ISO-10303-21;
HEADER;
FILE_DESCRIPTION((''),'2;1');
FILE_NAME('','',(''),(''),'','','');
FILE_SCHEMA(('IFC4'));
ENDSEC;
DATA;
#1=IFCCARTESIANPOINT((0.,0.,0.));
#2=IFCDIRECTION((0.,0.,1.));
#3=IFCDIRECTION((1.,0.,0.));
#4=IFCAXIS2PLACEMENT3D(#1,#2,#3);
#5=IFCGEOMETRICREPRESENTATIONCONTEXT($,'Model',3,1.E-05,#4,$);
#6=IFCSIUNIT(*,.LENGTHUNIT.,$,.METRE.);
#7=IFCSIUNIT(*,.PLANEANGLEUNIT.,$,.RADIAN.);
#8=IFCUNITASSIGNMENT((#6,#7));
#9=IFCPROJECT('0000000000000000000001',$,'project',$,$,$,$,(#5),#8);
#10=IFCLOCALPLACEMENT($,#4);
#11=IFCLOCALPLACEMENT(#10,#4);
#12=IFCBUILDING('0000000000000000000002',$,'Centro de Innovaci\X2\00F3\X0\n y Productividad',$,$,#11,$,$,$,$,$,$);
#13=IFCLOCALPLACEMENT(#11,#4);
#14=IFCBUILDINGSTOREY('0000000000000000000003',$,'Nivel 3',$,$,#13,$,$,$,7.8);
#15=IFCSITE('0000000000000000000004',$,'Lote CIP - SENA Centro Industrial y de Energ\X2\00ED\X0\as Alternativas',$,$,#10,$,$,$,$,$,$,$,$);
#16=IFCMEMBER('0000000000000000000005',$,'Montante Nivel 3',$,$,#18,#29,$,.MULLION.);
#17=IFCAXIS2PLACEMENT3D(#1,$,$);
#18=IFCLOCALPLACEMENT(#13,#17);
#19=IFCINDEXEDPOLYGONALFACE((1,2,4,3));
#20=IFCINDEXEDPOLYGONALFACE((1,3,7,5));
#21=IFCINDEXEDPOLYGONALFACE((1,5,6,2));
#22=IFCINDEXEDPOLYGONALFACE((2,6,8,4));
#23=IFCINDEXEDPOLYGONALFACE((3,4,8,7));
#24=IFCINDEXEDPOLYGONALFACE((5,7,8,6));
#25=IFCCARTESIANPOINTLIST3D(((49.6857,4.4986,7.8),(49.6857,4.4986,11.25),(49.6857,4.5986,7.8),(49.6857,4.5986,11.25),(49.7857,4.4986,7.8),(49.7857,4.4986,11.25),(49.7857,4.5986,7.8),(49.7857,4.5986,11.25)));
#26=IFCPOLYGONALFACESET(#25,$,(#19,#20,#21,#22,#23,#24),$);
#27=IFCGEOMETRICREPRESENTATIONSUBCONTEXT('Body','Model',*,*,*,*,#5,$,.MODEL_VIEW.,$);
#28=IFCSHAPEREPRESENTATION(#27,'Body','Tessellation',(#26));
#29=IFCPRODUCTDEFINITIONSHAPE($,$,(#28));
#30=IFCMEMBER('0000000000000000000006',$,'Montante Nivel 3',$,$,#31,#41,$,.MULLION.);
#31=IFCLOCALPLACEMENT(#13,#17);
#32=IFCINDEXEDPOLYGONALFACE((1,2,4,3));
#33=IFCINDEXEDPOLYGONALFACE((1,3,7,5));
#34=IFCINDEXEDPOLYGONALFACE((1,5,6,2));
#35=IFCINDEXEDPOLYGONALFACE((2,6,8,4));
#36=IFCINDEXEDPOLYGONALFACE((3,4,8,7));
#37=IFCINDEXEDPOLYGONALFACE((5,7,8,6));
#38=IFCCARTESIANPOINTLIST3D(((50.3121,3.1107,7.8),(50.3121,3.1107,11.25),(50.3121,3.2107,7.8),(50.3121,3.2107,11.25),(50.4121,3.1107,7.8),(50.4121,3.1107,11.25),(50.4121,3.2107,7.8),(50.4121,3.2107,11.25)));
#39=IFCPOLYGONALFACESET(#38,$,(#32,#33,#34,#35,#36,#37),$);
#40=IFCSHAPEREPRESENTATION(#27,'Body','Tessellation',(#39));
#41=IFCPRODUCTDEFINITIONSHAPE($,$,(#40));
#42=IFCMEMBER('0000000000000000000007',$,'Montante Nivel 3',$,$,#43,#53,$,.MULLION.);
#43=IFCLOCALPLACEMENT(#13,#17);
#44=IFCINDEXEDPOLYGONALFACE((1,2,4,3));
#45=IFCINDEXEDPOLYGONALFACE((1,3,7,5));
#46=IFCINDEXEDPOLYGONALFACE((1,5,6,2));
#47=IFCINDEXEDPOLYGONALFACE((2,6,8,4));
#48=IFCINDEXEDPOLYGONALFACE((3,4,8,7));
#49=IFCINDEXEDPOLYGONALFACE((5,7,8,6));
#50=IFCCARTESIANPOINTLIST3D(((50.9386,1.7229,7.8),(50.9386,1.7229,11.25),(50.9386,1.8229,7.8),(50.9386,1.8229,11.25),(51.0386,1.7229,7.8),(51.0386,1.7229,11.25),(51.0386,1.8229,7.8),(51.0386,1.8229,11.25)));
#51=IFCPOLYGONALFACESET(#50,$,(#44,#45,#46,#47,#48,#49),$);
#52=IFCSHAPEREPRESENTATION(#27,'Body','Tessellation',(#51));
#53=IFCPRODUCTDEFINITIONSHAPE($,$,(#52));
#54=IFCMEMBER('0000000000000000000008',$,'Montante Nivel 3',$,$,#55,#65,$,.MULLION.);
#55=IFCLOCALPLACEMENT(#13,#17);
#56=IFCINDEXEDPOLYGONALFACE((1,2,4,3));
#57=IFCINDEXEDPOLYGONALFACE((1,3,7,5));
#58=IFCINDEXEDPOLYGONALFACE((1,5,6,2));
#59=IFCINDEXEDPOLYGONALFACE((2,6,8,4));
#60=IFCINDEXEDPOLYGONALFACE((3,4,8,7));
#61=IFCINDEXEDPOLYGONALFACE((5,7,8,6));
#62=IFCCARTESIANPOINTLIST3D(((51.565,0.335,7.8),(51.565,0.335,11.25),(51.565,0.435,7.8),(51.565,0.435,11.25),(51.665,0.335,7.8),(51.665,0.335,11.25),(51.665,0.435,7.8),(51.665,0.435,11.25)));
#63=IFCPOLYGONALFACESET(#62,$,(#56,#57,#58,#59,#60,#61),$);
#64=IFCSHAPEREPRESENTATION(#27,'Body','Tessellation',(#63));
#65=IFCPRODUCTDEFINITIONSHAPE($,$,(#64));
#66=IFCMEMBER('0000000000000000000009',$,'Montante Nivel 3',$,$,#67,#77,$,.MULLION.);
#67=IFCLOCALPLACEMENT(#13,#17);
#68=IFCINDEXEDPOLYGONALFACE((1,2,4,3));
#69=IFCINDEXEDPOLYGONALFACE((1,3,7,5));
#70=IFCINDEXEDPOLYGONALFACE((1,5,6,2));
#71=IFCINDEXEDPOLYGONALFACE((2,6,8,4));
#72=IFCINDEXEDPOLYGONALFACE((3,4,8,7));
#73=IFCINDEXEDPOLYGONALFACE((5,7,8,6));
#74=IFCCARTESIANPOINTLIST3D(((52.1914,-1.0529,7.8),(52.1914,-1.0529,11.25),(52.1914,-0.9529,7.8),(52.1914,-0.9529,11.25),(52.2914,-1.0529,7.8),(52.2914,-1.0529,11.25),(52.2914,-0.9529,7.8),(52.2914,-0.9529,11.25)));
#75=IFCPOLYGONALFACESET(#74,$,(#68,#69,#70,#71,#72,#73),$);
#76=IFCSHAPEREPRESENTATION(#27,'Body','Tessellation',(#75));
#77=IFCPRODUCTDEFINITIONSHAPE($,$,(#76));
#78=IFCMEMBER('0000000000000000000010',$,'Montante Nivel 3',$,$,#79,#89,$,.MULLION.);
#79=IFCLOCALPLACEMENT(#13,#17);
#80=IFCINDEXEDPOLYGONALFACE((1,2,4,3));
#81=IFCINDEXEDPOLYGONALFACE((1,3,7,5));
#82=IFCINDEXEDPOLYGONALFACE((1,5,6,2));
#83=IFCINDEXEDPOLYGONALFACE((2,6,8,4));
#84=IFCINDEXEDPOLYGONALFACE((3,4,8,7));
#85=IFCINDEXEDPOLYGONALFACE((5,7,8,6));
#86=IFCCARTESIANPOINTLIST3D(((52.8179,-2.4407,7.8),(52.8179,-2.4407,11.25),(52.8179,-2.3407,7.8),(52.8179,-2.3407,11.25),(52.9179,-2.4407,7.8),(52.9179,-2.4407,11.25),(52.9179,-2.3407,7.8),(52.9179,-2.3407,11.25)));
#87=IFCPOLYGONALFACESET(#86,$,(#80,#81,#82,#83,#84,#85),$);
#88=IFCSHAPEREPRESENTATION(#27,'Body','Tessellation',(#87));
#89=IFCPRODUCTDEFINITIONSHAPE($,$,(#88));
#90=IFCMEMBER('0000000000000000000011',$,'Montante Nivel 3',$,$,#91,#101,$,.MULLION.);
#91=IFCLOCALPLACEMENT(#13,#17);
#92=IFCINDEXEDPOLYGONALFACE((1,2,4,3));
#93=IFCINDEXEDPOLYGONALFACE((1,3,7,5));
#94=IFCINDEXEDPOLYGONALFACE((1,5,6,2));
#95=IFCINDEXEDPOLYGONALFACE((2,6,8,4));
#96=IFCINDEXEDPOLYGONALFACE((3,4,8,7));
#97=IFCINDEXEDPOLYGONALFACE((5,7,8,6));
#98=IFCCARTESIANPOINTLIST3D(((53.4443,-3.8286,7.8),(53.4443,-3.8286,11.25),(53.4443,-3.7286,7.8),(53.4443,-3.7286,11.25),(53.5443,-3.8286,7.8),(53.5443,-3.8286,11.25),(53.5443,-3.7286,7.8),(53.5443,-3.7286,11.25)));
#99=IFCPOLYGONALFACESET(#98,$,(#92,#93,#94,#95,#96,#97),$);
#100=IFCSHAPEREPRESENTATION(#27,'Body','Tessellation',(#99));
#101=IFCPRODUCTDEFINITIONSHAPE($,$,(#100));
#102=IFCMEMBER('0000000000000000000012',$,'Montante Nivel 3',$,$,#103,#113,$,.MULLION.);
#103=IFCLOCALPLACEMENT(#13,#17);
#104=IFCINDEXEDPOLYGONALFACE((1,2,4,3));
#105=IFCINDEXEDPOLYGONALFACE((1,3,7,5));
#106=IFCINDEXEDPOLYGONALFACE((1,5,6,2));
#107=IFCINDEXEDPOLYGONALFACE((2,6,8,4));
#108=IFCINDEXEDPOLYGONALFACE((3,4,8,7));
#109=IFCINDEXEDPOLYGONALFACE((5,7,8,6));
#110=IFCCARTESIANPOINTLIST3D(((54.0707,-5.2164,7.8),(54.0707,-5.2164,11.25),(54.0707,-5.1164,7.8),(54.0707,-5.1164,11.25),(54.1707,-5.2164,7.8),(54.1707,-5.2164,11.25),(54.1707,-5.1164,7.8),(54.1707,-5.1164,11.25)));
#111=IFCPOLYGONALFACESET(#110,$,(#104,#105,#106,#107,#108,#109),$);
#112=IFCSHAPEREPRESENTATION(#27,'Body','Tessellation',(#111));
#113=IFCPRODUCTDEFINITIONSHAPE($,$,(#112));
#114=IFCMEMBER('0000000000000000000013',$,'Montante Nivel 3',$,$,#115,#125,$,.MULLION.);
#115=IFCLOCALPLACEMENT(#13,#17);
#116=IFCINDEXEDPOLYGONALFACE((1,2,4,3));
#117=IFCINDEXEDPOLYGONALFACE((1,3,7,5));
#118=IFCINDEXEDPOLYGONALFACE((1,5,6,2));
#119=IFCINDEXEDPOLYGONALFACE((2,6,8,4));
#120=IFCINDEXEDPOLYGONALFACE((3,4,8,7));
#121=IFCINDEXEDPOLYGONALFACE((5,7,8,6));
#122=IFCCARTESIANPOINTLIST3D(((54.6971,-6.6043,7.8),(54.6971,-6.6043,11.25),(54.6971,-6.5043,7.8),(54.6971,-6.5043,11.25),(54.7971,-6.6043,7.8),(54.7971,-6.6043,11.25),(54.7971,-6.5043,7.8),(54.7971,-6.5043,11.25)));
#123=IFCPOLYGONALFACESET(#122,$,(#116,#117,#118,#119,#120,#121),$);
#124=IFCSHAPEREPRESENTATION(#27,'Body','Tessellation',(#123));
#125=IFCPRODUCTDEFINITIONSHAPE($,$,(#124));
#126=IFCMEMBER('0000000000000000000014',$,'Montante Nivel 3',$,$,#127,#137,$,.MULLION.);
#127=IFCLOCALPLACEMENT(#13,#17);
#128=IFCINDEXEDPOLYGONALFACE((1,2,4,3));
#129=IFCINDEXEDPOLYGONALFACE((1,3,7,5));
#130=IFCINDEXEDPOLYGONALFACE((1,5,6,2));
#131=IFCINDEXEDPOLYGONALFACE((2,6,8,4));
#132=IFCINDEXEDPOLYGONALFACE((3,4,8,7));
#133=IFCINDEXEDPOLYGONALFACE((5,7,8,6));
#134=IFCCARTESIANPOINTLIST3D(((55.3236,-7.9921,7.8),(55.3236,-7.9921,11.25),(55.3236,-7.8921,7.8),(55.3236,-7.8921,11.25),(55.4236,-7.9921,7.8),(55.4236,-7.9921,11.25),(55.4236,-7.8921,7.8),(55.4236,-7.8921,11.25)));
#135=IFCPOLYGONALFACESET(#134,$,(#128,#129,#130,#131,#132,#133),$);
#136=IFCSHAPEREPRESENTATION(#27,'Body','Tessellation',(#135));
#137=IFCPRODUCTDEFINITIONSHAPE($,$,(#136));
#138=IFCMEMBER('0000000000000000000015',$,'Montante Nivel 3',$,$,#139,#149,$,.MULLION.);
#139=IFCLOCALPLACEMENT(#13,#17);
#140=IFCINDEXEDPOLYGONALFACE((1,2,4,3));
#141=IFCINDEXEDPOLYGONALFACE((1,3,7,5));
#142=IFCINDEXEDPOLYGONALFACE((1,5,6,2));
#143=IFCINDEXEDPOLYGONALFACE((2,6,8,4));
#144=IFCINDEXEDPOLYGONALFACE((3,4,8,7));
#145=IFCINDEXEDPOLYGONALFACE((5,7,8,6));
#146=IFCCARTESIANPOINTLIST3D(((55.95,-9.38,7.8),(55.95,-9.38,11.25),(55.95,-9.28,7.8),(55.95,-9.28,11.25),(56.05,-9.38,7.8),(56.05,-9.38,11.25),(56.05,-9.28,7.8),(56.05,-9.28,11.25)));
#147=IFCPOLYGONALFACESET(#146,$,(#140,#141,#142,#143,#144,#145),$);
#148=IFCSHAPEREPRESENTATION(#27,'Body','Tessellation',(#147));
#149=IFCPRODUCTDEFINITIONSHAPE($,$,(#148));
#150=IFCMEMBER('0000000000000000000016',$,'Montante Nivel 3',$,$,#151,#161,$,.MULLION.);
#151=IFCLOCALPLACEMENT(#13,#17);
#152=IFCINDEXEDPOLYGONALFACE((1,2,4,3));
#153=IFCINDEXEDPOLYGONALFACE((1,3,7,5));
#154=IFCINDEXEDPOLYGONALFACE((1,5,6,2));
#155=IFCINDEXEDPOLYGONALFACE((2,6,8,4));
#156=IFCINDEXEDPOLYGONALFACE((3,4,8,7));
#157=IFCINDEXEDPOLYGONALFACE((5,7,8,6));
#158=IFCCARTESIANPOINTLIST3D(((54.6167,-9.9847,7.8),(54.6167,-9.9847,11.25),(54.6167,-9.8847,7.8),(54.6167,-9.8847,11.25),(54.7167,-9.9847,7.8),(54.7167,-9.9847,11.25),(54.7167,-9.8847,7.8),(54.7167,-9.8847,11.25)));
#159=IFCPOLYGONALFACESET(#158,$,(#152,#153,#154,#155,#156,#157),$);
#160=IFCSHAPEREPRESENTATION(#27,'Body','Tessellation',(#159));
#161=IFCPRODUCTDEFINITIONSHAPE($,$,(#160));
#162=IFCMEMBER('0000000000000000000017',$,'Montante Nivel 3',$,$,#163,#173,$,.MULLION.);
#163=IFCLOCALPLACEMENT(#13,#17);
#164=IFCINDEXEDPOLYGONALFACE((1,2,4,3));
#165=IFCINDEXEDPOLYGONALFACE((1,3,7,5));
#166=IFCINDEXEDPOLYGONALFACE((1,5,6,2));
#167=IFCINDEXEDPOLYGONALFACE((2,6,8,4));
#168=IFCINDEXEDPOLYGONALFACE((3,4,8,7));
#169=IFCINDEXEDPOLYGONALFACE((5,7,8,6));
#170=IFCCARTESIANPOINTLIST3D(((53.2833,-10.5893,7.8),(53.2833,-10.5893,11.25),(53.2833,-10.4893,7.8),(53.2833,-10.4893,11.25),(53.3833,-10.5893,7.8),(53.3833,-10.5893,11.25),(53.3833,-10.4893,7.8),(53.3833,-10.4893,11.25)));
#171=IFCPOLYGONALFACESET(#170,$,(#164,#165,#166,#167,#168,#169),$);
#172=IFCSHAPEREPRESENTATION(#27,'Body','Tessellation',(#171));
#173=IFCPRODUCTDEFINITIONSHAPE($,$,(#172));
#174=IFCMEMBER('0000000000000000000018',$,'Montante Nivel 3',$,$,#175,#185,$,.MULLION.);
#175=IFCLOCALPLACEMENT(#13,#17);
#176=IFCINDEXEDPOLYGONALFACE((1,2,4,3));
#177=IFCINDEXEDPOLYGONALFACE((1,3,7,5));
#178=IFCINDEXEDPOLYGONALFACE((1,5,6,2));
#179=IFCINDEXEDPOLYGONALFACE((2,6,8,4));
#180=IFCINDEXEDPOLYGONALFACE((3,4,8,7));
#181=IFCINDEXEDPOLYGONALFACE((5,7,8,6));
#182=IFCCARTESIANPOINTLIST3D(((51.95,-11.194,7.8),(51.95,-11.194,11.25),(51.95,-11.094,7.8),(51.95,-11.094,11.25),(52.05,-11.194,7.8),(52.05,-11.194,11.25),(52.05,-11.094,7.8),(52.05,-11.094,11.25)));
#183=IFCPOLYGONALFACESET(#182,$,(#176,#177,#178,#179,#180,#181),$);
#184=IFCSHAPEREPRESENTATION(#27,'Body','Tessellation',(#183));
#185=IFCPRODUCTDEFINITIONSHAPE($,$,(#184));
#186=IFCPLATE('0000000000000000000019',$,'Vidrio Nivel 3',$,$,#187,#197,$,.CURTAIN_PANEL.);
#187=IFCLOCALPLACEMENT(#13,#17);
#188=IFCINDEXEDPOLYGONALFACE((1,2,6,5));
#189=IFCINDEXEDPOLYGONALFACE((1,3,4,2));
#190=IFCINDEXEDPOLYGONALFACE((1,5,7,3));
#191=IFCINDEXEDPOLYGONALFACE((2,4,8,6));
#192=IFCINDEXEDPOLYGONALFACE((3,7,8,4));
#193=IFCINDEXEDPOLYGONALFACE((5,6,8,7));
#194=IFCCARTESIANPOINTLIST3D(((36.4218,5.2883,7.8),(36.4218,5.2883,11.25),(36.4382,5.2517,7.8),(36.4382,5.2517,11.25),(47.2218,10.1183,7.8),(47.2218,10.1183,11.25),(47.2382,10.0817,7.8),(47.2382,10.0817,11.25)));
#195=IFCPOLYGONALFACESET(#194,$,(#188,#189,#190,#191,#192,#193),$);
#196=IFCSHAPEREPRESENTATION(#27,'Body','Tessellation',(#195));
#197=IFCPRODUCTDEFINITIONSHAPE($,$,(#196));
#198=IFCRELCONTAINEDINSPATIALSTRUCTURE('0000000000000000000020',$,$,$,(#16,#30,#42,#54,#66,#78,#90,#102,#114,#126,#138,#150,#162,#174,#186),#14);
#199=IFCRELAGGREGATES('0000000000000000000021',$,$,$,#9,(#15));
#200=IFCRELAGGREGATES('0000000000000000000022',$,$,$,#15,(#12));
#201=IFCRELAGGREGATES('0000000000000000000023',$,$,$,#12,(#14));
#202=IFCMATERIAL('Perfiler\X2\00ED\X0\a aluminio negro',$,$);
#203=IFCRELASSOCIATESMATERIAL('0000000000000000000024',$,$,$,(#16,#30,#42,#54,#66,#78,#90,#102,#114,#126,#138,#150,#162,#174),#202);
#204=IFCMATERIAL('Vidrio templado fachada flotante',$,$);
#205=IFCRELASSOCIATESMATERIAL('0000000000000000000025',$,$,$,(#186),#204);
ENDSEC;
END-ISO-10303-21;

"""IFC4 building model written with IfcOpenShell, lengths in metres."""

from ifc_helpers import new_model, si_unit, frame, origin_with_axes, place, context, subcontext, project, spatial, polyline, outline, extrude, material, element, save


model = new_model("IFC4")

# Units and contexts
model_context = context("Model", 3, precision=1e-05, world=origin_with_axes())
body_context = subcontext(model_context, "Body", "Model", "MODEL_VIEW")
ifc_project = project(units=[si_unit("LENGTHUNIT", "METRE"), si_unit("PLANEANGLEUNIT", "RADIAN")], contexts=[model_context])

# Site, building, storey
site_placement = place(None, origin_with_axes())
site = spatial("IfcSite", under=ifc_project, at=site_placement, Name="Lote CIP - SENA Centro Industrial y de Energías Alternativas")
building_placement = place(site_placement, origin_with_axes())
building = spatial("IfcBuilding", under=site, at=building_placement, Name="Centro de Innovación y Productividad")
storey_placement = place(building_placement, origin_with_axes())
storey = spatial("IfcBuildingStorey", under=building, at=storey_placement, Name="Nivel 3", Elevation=7.8)

# Members
ifc_material_1 = material(Name="Perfilería aluminio negro")
member_1_placement = place(storey_placement, origin_with_axes())
element("IfcMember", 1, at=member_1_placement, inside=storey, material=ifc_material_1, Name="Montante Nivel 3", PredefinedType="MULLION", context=body_context, shape_type="SweptSolid", body=[
    extrude(outline(polyline([(49.7857, 4.5986), (49.7857, 4.4986), (49.6857, 4.4986), (49.6857, 4.5986), (49.7857, 4.5986)])), frame((0.0, 0.0, 7.8)), (0.0, 0.0, 1.0), 3.45),
])
member_2_placement = place(storey_placement, origin_with_axes())
element("IfcMember", 2, at=member_2_placement, inside=storey, material=ifc_material_1, Name="Montante Nivel 3", PredefinedType="MULLION", context=body_context, shape_type="SweptSolid", body=[
    extrude(outline(polyline([(50.4121, 3.2107), (50.4121, 3.1107), (50.3121, 3.1107), (50.3121, 3.2107), (50.4121, 3.2107)])), frame((0.0, 0.0, 7.8)), (0.0, 0.0, 1.0), 3.45),
])
member_3_placement = place(storey_placement, origin_with_axes())
element("IfcMember", 3, at=member_3_placement, inside=storey, material=ifc_material_1, Name="Montante Nivel 3", PredefinedType="MULLION", context=body_context, shape_type="SweptSolid", body=[
    extrude(outline(polyline([(51.0386, 1.8229), (51.0386, 1.7229), (50.9386, 1.7229), (50.9386, 1.8229), (51.0386, 1.8229)])), frame((0.0, 0.0, 7.8)), (0.0, 0.0, 1.0), 3.45),
])
member_4_placement = place(storey_placement, origin_with_axes())
element("IfcMember", 4, at=member_4_placement, inside=storey, material=ifc_material_1, Name="Montante Nivel 3", PredefinedType="MULLION", context=body_context, shape_type="SweptSolid", body=[
    extrude(outline(polyline([(51.665, 0.435), (51.665, 0.335), (51.565, 0.335), (51.565, 0.435), (51.665, 0.435)])), frame((0.0, 0.0, 7.8)), (0.0, 0.0, 1.0), 3.45),
])
member_5_placement = place(storey_placement, origin_with_axes())
element("IfcMember", 5, at=member_5_placement, inside=storey, material=ifc_material_1, Name="Montante Nivel 3", PredefinedType="MULLION", context=body_context, shape_type="SweptSolid", body=[
    extrude(outline(polyline([(52.2914, -0.9529), (52.2914, -1.0529), (52.1914, -1.0529), (52.1914, -0.9529), (52.2914, -0.9529)])), frame((0.0, 0.0, 7.8)), (0.0, 0.0, 1.0), 3.45),
])
member_6_placement = place(storey_placement, origin_with_axes())
element("IfcMember", 6, at=member_6_placement, inside=storey, material=ifc_material_1, Name="Montante Nivel 3", PredefinedType="MULLION", context=body_context, shape_type="SweptSolid", body=[
    extrude(outline(polyline([(52.9179, -2.3407), (52.9179, -2.4407), (52.8179, -2.4407), (52.8179, -2.3407), (52.9179, -2.3407)])), frame((0.0, 0.0, 7.8)), (0.0, 0.0, 1.0), 3.45),
])
member_7_placement = place(storey_placement, origin_with_axes())
element("IfcMember", 7, at=member_7_placement, inside=storey, material=ifc_material_1, Name="Montante Nivel 3", PredefinedType="MULLION", context=body_context, shape_type="SweptSolid", body=[
    extrude(outline(polyline([(53.5443, -3.7286), (53.5443, -3.8286), (53.4443, -3.8286), (53.4443, -3.7286), (53.5443, -3.7286)])), frame((0.0, 0.0, 7.8)), (0.0, 0.0, 1.0), 3.45),
])
member_8_placement = place(storey_placement, origin_with_axes())
element("IfcMember", 8, at=member_8_placement, inside=storey, material=ifc_material_1, Name="Montante Nivel 3", PredefinedType="MULLION", context=body_context, shape_type="SweptSolid", body=[
    extrude(outline(polyline([(54.1707, -5.1164), (54.1707, -5.2164), (54.0707, -5.2164), (54.0707, -5.1164), (54.1707, -5.1164)])), frame((0.0, 0.0, 7.8)), (0.0, 0.0, 1.0), 3.45),
])
member_9_placement = place(storey_placement, origin_with_axes())
element("IfcMember", 9, at=member_9_placement, inside=storey, material=ifc_material_1, Name="Montante Nivel 3", PredefinedType="MULLION", context=body_context, shape_type="SweptSolid", body=[
    extrude(outline(polyline([(54.7971, -6.5043), (54.7971, -6.6043), (54.6971, -6.6043), (54.6971, -6.5043), (54.7971, -6.5043)])), frame((0.0, 0.0, 7.8)), (0.0, 0.0, 1.0), 3.45),
])
member_10_placement = place(storey_placement, origin_with_axes())
element("IfcMember", 10, at=member_10_placement, inside=storey, material=ifc_material_1, Name="Montante Nivel 3", PredefinedType="MULLION", context=body_context, shape_type="SweptSolid", body=[
    extrude(outline(polyline([(55.4236, -7.8921), (55.4236, -7.9921), (55.3236, -7.9921), (55.3236, -7.8921), (55.4236, -7.8921)])), frame((0.0, 0.0, 7.8)), (0.0, 0.0, 1.0), 3.45),
])
for number, where, z_axis, x_axis, name in (
    (11, (0.0, 0.0, 0.0), (0.0, 0.0, 1.0), (1.0, 0.0, 0.0), "Montante Nivel 3"),
):
    element("IfcMember", number, at=place(storey_placement, frame(where, z_axis=z_axis, x_axis=x_axis)), inside=storey, material=ifc_material_1, Name=name, PredefinedType="MULLION", context=body_context, shape_type="SweptSolid", body=[
        extrude(outline(polyline([(56.05, -9.28), (56.05, -9.38), (55.95, -9.38), (55.95, -9.28), (56.05, -9.28)])), frame((0.0, 0.0, 7.8)), (0.0, 0.0, 1.0), 3.45),
    ])
member_11_placement = place(storey_placement, origin_with_axes())
element("IfcMember", 12, at=member_11_placement, inside=storey, material=ifc_material_1, Name="Montante Nivel 3", PredefinedType="MULLION", context=body_context, shape_type="SweptSolid", body=[
    extrude(outline(polyline([(54.7167, -9.8847), (54.7167, -9.9847), (54.6167, -9.9847), (54.6167, -9.8847), (54.7167, -9.8847)])), frame((0.0, 0.0, 7.8)), (0.0, 0.0, 1.0), 3.45),
])
member_12_placement = place(storey_placement, origin_with_axes())
element("IfcMember", 13, at=member_12_placement, inside=storey, material=ifc_material_1, Name="Montante Nivel 3", PredefinedType="MULLION", context=body_context, shape_type="SweptSolid", body=[
    extrude(outline(polyline([(53.3833, -10.4893), (53.3833, -10.5893), (53.2833, -10.5893), (53.2833, -10.4893), (53.3833, -10.4893)])), frame((0.0, 0.0, 7.8)), (0.0, 0.0, 1.0), 3.45),
])
member_13_placement = place(storey_placement, origin_with_axes())
element("IfcMember", 14, at=member_13_placement, inside=storey, material=ifc_material_1, Name="Montante Nivel 3", PredefinedType="MULLION", context=body_context, shape_type="SweptSolid", body=[
    extrude(outline(polyline([(52.05, -11.094), (52.05, -11.194), (51.95, -11.194), (51.95, -11.094), (52.05, -11.094)])), frame((0.0, 0.0, 7.8)), (0.0, 0.0, 1.0), 3.45),
])

# Plate
ifc_material_2 = material(Name="Vidrio templado fachada flotante")
plate_1_placement = place(storey_placement, origin_with_axes())
element("IfcPlate", 15, at=plate_1_placement, inside=storey, material=ifc_material_2, Name="Vidrio Nivel 3", PredefinedType="CURTAIN_PANEL", context=body_context, shape_type="SweptSolid", body=[
    extrude(outline(polyline([(47.2382, 10.0817), (36.4382, 5.2517), (36.4218, 5.2883), (47.2218, 10.1183), (47.2382, 10.0817)])), frame((0.0, 0.0, 7.8)), (0.0, 0.0, 1.0), 3.45),
])

save(model, "model.ifc")
